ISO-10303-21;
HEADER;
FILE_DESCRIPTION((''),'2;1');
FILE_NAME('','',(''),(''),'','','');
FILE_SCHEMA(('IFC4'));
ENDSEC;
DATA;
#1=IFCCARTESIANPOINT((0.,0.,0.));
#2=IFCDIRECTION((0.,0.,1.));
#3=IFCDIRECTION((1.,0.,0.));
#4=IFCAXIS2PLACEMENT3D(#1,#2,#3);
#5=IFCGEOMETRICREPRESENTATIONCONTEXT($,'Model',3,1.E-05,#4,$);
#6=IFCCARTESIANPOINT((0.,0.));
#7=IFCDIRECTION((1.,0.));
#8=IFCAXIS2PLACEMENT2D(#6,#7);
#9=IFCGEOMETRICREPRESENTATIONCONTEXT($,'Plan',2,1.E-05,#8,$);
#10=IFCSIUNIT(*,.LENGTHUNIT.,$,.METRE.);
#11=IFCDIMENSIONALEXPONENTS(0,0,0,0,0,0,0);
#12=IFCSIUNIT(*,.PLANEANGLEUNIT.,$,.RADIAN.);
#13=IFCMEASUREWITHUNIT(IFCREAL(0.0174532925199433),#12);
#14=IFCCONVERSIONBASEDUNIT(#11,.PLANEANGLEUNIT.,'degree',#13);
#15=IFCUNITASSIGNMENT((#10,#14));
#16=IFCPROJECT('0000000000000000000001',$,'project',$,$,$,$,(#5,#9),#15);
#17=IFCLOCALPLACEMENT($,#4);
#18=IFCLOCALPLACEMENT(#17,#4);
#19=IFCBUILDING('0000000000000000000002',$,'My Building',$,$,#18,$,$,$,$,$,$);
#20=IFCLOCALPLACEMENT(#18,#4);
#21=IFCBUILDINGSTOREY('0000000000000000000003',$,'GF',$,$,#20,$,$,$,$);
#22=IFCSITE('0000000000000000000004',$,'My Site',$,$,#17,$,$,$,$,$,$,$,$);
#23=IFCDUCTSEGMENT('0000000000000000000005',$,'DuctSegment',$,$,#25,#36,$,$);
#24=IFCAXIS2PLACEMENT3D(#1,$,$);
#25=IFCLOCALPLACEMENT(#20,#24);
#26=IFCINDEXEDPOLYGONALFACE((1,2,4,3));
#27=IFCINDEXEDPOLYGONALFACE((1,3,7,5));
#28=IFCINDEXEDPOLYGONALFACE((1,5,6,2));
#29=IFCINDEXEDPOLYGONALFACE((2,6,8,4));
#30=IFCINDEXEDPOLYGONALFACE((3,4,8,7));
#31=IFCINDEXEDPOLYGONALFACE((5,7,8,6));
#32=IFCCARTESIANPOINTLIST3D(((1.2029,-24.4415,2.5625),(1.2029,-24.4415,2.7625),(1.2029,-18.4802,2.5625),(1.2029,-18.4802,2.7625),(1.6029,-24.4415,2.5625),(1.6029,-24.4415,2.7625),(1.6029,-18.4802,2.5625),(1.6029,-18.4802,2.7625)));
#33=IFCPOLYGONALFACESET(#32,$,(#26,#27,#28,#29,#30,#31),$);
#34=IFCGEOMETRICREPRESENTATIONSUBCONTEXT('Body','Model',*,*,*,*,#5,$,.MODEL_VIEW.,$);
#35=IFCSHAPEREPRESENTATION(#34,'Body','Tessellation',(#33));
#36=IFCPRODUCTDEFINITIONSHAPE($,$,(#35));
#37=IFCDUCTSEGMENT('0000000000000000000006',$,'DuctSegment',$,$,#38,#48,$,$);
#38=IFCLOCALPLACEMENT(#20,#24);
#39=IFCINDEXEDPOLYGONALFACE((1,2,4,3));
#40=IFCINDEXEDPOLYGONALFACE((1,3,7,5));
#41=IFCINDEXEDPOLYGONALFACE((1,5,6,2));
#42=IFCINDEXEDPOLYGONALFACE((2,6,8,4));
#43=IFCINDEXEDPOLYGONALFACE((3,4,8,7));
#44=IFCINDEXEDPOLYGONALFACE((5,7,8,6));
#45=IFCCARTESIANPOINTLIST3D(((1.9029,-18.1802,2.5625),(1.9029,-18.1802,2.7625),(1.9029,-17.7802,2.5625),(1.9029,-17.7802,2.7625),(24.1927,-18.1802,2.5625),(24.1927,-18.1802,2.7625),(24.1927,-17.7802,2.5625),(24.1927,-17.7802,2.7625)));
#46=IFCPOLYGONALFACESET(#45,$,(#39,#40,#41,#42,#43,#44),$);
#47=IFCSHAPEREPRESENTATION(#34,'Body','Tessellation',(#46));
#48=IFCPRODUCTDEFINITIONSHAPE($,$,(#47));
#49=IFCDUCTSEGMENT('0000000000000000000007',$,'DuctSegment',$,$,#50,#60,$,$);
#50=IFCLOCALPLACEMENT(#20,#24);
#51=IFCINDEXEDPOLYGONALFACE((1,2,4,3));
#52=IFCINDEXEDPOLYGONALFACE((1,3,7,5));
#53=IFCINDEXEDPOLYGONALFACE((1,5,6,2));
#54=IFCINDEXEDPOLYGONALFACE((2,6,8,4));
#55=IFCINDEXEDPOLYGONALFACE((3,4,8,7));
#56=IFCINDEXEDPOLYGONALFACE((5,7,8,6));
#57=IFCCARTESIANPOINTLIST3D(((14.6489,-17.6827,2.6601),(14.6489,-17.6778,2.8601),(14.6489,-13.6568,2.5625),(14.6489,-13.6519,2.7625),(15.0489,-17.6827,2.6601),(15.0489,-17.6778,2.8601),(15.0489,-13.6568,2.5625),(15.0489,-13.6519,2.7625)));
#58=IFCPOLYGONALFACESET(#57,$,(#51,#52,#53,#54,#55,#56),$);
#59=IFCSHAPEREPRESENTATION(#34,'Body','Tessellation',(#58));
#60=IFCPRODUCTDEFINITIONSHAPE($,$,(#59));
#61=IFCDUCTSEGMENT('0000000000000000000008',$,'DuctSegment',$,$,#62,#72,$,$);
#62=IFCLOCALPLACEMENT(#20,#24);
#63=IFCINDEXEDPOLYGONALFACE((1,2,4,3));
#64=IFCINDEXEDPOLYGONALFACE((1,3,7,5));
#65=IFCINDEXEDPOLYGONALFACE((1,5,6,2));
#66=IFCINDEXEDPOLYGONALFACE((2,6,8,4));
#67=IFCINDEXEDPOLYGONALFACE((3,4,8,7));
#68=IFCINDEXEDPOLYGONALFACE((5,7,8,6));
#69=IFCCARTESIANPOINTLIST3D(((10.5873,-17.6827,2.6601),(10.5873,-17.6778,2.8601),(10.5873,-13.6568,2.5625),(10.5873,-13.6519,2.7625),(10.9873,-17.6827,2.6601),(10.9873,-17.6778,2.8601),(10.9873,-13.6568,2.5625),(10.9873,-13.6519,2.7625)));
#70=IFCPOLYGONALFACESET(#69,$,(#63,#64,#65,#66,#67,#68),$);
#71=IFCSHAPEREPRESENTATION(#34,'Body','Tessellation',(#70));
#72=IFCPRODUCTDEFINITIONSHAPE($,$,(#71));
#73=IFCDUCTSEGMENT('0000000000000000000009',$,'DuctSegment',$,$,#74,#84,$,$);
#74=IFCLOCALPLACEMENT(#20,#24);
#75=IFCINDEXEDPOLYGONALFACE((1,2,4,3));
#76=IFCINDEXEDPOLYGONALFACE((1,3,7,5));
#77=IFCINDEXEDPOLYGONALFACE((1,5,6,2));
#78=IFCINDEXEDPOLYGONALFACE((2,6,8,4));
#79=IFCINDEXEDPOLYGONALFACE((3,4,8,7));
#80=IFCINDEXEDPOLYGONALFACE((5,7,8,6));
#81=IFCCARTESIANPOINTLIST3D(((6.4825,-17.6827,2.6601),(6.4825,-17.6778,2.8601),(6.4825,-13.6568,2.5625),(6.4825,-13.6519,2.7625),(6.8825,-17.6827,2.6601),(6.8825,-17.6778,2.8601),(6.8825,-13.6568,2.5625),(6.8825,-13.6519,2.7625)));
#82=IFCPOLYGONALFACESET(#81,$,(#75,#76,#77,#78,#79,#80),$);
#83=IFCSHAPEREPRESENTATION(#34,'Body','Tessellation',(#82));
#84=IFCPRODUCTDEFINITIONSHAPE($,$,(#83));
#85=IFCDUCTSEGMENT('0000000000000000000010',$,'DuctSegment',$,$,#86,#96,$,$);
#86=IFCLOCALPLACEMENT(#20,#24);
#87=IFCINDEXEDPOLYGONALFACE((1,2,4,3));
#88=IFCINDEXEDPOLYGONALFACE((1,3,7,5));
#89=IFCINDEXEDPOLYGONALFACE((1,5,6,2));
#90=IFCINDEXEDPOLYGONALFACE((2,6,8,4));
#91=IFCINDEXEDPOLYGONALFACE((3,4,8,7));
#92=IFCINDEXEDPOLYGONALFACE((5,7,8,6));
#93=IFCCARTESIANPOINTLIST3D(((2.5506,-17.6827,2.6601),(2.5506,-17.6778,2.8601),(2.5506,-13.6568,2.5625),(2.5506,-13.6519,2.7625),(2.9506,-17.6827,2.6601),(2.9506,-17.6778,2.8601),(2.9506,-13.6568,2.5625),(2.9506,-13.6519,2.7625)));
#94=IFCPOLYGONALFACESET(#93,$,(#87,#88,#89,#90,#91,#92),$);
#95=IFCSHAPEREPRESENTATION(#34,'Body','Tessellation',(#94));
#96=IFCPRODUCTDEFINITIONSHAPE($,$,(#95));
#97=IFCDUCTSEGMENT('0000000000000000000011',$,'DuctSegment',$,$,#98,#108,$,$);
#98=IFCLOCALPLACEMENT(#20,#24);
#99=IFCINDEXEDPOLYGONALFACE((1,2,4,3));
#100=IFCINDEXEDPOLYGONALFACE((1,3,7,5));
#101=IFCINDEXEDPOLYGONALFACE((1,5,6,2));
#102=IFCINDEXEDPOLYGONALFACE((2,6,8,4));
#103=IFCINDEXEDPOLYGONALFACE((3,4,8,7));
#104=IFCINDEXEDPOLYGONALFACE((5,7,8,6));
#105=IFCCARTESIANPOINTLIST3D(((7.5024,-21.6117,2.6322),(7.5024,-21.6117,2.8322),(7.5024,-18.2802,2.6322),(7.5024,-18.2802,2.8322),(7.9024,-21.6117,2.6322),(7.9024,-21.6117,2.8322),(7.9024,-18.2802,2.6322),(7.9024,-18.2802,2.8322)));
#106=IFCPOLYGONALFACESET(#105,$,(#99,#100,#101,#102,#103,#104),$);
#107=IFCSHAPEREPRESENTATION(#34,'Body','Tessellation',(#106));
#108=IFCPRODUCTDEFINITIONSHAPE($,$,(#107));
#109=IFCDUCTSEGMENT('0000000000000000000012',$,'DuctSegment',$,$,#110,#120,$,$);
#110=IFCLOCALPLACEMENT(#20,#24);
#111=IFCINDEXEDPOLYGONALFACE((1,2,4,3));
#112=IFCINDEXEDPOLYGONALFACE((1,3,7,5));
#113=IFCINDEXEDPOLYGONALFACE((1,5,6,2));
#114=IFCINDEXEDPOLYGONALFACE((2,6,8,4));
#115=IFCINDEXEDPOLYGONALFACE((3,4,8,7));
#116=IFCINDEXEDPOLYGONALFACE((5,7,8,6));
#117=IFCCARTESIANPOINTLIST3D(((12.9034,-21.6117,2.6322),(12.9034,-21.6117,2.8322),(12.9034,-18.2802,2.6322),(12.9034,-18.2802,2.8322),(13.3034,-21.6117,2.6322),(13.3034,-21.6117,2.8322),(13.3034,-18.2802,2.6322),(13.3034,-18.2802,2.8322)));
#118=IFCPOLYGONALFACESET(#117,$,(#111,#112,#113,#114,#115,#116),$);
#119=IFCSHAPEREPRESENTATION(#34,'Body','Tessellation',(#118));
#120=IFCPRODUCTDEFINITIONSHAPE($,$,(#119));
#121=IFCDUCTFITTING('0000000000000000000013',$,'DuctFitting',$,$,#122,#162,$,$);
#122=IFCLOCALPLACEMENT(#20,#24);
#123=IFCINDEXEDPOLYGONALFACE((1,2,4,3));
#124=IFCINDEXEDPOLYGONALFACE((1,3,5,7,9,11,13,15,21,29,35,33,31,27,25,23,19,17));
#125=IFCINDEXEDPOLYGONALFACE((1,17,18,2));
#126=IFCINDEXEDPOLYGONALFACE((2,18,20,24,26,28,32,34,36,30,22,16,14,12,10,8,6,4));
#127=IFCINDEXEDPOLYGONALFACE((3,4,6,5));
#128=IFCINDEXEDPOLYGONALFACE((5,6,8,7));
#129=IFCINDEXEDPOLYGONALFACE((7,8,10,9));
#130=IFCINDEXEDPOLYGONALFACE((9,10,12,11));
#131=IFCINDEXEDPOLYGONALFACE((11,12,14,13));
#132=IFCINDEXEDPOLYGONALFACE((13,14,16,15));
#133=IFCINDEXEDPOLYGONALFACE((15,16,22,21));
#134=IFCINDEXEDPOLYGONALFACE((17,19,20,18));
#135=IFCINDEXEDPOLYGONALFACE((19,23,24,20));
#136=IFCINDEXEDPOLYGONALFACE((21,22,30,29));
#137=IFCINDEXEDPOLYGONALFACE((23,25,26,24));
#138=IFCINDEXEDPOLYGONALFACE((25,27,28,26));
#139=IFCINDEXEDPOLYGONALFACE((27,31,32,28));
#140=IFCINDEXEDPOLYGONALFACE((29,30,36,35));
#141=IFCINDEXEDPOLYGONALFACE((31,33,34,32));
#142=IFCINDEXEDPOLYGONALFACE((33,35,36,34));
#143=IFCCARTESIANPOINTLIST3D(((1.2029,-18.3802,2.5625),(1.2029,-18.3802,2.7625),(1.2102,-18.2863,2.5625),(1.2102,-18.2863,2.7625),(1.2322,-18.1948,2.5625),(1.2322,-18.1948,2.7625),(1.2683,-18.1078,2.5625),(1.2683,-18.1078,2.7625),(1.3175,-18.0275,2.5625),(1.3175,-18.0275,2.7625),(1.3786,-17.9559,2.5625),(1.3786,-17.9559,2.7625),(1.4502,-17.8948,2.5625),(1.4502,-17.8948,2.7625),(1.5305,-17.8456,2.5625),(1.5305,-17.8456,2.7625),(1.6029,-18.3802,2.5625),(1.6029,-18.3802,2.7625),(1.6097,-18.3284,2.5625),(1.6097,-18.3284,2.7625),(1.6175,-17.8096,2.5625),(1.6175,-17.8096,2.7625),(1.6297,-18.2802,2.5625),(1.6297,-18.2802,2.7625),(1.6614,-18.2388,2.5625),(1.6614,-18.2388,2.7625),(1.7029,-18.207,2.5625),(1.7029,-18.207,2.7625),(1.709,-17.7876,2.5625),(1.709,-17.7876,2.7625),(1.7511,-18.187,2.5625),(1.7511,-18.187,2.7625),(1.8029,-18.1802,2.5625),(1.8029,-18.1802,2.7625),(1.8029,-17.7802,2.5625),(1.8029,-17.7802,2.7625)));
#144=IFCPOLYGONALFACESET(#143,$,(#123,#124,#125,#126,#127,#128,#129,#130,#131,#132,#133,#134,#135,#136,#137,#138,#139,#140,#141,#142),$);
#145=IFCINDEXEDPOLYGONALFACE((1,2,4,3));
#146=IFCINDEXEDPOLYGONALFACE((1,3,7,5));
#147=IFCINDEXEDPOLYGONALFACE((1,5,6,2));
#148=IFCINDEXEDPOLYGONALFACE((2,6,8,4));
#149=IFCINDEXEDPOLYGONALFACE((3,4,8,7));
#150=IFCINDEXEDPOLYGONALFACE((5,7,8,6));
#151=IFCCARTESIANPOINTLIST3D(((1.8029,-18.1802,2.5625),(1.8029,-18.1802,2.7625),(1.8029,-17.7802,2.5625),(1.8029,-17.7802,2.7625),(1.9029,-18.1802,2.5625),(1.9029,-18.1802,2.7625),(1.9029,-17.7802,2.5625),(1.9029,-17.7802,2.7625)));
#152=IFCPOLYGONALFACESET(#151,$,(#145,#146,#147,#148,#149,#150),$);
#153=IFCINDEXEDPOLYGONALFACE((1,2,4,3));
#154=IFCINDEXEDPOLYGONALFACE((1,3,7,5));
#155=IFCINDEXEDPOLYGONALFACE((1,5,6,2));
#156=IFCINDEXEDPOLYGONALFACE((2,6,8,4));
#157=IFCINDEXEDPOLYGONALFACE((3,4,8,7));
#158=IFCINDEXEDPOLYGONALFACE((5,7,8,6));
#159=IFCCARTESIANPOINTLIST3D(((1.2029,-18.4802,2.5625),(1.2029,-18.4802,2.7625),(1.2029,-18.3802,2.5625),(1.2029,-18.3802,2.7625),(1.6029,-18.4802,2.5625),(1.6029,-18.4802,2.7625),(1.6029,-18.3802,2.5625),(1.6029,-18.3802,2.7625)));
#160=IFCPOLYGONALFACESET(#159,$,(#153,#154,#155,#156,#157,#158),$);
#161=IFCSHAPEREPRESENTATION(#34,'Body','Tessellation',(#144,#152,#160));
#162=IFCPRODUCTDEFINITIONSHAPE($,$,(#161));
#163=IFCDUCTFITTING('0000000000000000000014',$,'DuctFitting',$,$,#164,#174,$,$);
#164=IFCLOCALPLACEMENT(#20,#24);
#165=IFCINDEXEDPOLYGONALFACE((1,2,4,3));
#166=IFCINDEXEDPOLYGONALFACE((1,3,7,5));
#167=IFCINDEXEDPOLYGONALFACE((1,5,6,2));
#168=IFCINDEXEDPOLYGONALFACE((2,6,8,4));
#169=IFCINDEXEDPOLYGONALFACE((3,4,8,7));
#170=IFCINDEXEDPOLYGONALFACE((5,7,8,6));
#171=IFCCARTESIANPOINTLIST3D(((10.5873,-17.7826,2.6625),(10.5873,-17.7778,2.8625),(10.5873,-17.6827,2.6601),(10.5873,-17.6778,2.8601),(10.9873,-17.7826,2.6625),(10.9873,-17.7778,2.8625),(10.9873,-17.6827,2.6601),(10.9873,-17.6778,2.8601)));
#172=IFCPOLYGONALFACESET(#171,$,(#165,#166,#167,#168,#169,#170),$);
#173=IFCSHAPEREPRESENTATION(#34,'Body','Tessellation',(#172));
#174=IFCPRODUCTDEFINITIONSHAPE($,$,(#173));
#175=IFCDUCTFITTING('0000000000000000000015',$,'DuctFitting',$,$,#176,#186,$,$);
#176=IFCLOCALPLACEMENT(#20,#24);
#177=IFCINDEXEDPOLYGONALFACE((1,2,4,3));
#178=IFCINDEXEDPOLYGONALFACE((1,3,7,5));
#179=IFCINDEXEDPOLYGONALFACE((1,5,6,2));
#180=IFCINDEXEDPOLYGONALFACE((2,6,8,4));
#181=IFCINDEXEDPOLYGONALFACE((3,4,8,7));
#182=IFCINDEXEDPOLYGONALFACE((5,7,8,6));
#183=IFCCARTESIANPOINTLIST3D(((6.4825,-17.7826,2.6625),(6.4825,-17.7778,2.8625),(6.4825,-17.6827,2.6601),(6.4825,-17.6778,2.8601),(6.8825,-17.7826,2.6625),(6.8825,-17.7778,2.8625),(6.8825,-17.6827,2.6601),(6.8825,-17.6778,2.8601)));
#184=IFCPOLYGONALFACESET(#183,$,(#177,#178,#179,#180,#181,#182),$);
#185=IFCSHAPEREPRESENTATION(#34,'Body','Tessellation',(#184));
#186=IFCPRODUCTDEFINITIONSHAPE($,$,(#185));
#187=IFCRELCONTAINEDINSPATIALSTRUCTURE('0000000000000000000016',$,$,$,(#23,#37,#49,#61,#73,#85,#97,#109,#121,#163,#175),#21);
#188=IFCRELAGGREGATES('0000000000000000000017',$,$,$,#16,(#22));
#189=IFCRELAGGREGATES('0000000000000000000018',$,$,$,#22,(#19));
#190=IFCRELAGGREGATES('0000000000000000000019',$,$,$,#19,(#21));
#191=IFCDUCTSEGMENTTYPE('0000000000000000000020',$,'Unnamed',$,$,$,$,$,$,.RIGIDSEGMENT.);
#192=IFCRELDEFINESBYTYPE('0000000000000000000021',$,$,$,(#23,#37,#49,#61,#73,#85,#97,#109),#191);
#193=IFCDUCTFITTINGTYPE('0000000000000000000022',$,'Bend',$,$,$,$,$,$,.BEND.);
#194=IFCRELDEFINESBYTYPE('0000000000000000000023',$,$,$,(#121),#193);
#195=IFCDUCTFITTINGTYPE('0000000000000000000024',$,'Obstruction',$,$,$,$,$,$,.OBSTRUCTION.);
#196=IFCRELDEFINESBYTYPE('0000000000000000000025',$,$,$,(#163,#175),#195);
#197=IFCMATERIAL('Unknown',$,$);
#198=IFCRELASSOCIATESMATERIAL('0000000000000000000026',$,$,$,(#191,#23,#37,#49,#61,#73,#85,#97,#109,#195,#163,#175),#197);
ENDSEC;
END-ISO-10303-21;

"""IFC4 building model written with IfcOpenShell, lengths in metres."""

from ifc_helpers import new_model, entity, si_unit, converted_unit, frame, origin_with_axes, origin_2d_with_axis, place, context, subcontext, project, spatial, line, arc, indexed_curve, rectangle, outline, extrude, source, transform, mapped, material, material_profile, profile_set, profile_usage, type_object, type_shapes, element, save


model = new_model("IFC4")

# Units and contexts
model_context = context("Model", 3, precision=1e-05, world=origin_with_axes())
plan_context = context("Plan", 2, precision=1e-05, world=origin_2d_with_axis())
body_context_1 = subcontext(model_context, "Body", "Model", "MODEL_VIEW")
ifc_project = project(units=[si_unit("LENGTHUNIT", "METRE"), converted_unit("PLANEANGLEUNIT", "degree", entity("IfcReal", 0.0174532925199433), si_unit("PLANEANGLEUNIT", "RADIAN"), dimensions=[0, 0, 0, 0, 0, 0, 0])], contexts=[model_context, plan_context])

# Site, building, storey
site_placement = place(None, origin_with_axes())
site = spatial("IfcSite", under=ifc_project, at=site_placement, Name="My Site")
building_placement = place(site_placement, origin_with_axes())
building = spatial("IfcBuilding", under=site, at=building_placement, Name="My Building")
storey_placement = place(building_placement, origin_with_axes())
storey = spatial("IfcBuildingStorey", under=building, at=storey_placement, Name="GF")

# Shared definitions
ifc_material = material(Name="Unknown")

# Duct segments
ifc_material_profile_1 = material_profile(ifc_material, rectangle(XDim=0.4, YDim=0.2))
ifc_profile_set_1 = profile_set([ifc_material_profile_1])
ifc_profile_usage_1 = profile_usage(ifc_profile_set_1, cardinal=5)
duct_segment_type = type_object("IfcDuctSegmentType", Name="Unnamed", PredefinedType="RIGIDSEGMENT", material=ifc_profile_set_1)
duct_segment_1_placement = place(storey_placement, frame((1.4029, -18.4802, 2.6625), z_axis=(0.0, -1.0, 0.0), x_axis=(1.0, 0.0, 0.0)))
element("IfcDuctSegment", 1, at=duct_segment_1_placement, inside=storey, type_object=duct_segment_type, material=ifc_profile_usage_1, Name="DuctSegment", context=body_context_1, shape_type="SweptSolid", body=[
    extrude(rectangle(XDim=0.4, YDim=0.2), origin_with_axes(), (0.0, 0.0, 1.0), 5.9613),
])
ifc_profile_usage_2 = profile_usage(ifc_profile_set_1, cardinal=5)
duct_segment_2_placement = place(storey_placement, frame((1.9029, -17.9802, 2.6625), z_axis=(1.0, 0.0, 0.0), x_axis=(0.0, 1.0, 0.0)))
element("IfcDuctSegment", 2, at=duct_segment_2_placement, inside=storey, type_object=duct_segment_type, material=ifc_profile_usage_2, Name="DuctSegment", context=body_context_1, shape_type="SweptSolid", body=[
    extrude(rectangle(XDim=0.4, YDim=0.2), origin_with_axes(), (0.0, 0.0, 1.0), 22.2899),
])
ifc_profile_usage_3 = profile_usage(ifc_profile_set_1, cardinal=5)
duct_segment_3_placement = place(storey_placement, frame((14.8489, -17.6802, 2.7601), z_axis=(0.0, 0.999706, -0.02423), x_axis=(-1.0, 0.0, 0.0)))
element("IfcDuctSegment", 3, at=duct_segment_3_placement, inside=storey, type_object=duct_segment_type, material=ifc_profile_usage_3, Name="DuctSegment", context=body_context_1, shape_type="SweptSolid", body=[
    extrude(rectangle(XDim=0.4, YDim=0.2), origin_with_axes(), (0.0, 0.0, 1.0), 4.0271),
])
ifc_profile_usage_4 = profile_usage(ifc_profile_set_1, cardinal=5)
duct_segment_4_placement = place(storey_placement, frame((10.7873, -17.6802, 2.7601), z_axis=(0.0, 0.999706, -0.02423), x_axis=(-1.0, 0.0, 0.0)))
element("IfcDuctSegment", 4, at=duct_segment_4_placement, inside=storey, type_object=duct_segment_type, material=ifc_profile_usage_4, Name="DuctSegment", context=body_context_1, shape_type="SweptSolid", body=[
    extrude(rectangle(XDim=0.4, YDim=0.2), origin_with_axes(), (0.0, 0.0, 1.0), 4.0271),
])
ifc_profile_usage_5 = profile_usage(ifc_profile_set_1, cardinal=5)
duct_segment_5_placement = place(storey_placement, frame((6.6825, -17.6802, 2.7601), z_axis=(0.0, 0.999706, -0.02423), x_axis=(-1.0, 0.0, 0.0)))
element("IfcDuctSegment", 5, at=duct_segment_5_placement, inside=storey, type_object=duct_segment_type, material=ifc_profile_usage_5, Name="DuctSegment", context=body_context_1, shape_type="SweptSolid", body=[
    extrude(rectangle(XDim=0.4, YDim=0.2), origin_with_axes(), (0.0, 0.0, 1.0), 4.0271),
])
ifc_profile_usage_6 = profile_usage(ifc_profile_set_1, cardinal=5)
duct_segment_6_placement = place(storey_placement, frame((2.7506, -17.6802, 2.7601), z_axis=(0.0, 0.999706, -0.02423), x_axis=(-1.0, 0.0, 0.0)))
element("IfcDuctSegment", 6, at=duct_segment_6_placement, inside=storey, type_object=duct_segment_type, material=ifc_profile_usage_6, Name="DuctSegment", context=body_context_1, shape_type="SweptSolid", body=[
    extrude(rectangle(XDim=0.4, YDim=0.2), origin_with_axes(), (0.0, 0.0, 1.0), 4.0271),
])
ifc_profile_usage_7 = profile_usage(ifc_profile_set_1, cardinal=5)
duct_segment_7_placement = place(storey_placement, frame((7.7024, -18.2802, 2.7322), z_axis=(0.0, -1.0, 0.0), x_axis=(1.0, 0.0, 0.0)))
element("IfcDuctSegment", 7, at=duct_segment_7_placement, inside=storey, type_object=duct_segment_type, material=ifc_profile_usage_7, Name="DuctSegment", context=body_context_1, shape_type="SweptSolid", body=[
    extrude(rectangle(XDim=0.4, YDim=0.2), origin_with_axes(), (0.0, 0.0, 1.0), 3.3315),
])
ifc_profile_usage_8 = profile_usage(ifc_profile_set_1, cardinal=5)
duct_segment_8_placement = place(storey_placement, frame((13.1034, -18.2802, 2.7322), z_axis=(0.0, -1.0, 0.0), x_axis=(1.0, 0.0, 0.0)))
element("IfcDuctSegment", 8, at=duct_segment_8_placement, inside=storey, type_object=duct_segment_type, material=ifc_profile_usage_8, Name="DuctSegment", context=body_context_1, shape_type="SweptSolid", body=[
    extrude(rectangle(XDim=0.4, YDim=0.2), origin_with_axes(), (0.0, 0.0, 1.0), 3.3315),
])

# Duct fittings
duct_fitting_type_1 = type_object("IfcDuctFittingType", Name="Bend", PredefinedType="BEND")
shared_shape_1 = source(origin_with_axes(), body_context_1, "Body", "SweptSolid", [
    extrude(outline(indexed_curve([(0.2, 0.0), (0.2586, -0.1414), (0.4, -0.2), (0.4, -0.6), (-0.0243, -0.4243), (-0.2, 0.0)], segments=[arc(1, 2, 3), line(3, 4), arc(4, 5, 6), line(6, 1)])), frame((0.0, -0.1, -0.1), z_axis=(0.0, -1.0, 0.0), x_axis=(1.0, 0.0, 0.0)), (0.0, 0.0, -1.0), 0.2),
    extrude(rectangle(XDim=0.4, YDim=0.2), origin_with_axes(), (0.0, 0.0, -1.0), 0.1),
    extrude(rectangle(XDim=0.4, YDim=0.2), frame((0.4, 0.0, -0.5), z_axis=(1.0, 0.0, 0.0), x_axis=(0.0, 0.0, 1.0)), (0.0, 0.0, 1.0), 0.1),
])
type_shapes(duct_fitting_type_1, [shared_shape_1])
duct_fitting_1_placement = place(storey_placement, frame((1.9029, -17.9802, 2.6625), z_axis=(1.0, 0.0, 0.0), x_axis=(0.0, -1.0, 0.0)))
element("IfcDuctFitting", 9, at=duct_fitting_1_placement, inside=storey, type_object=duct_fitting_type_1, Name="DuctFitting", context=body_context_1, shape_type="MappedRepresentation", body=[
    mapped(shared_shape_1, transform((0.0, 0.0, 0.0), x_axis=(1.0, 0.0, 0.0), y_axis=(0.0, 1.0, 0.0), z_axis=(0.0, 0.0, 1.0), scale=1.0)),
])
ifc_material_profile_2 = material_profile(ifc_material, rectangle(XDim=0.4, YDim=0.2))
ifc_profile_set_2 = profile_set([ifc_material_profile_2])
ifc_profile_usage_9 = profile_usage(ifc_profile_set_2, cardinal=5)
duct_fitting_type_2 = type_object("IfcDuctFittingType", Name="Obstruction", PredefinedType="OBSTRUCTION", material=ifc_profile_set_2)
duct_fitting_2_placement = place(storey_placement, frame((10.7873, -17.7802, 2.7625), z_axis=(0.0, 0.999706, -0.02423), x_axis=(-1.0, 0.0, 0.0)))
element("IfcDuctFitting", 10, at=duct_fitting_2_placement, inside=storey, type_object=duct_fitting_type_2, material=ifc_profile_usage_9, Name="DuctFitting", context=body_context_1, shape_type="SweptSolid", body=[
    extrude(rectangle(XDim=0.4, YDim=0.2), origin_with_axes(), (0.0, 0.0, 1.0), 0.1),
])
ifc_profile_usage_10 = profile_usage(ifc_profile_set_2, cardinal=5)
duct_fitting_3_placement = place(storey_placement, frame((6.6825, -17.7802, 2.7625), z_axis=(0.0, 0.999706, -0.02423), x_axis=(-1.0, 0.0, 0.0)))
element("IfcDuctFitting", 11, at=duct_fitting_3_placement, inside=storey, type_object=duct_fitting_type_2, material=ifc_profile_usage_10, Name="DuctFitting", context=body_context_1, shape_type="SweptSolid", body=[
    extrude(rectangle(XDim=0.4, YDim=0.2), origin_with_axes(), (0.0, 0.0, 1.0), 0.1),
])

save(model, "model.ifc")
